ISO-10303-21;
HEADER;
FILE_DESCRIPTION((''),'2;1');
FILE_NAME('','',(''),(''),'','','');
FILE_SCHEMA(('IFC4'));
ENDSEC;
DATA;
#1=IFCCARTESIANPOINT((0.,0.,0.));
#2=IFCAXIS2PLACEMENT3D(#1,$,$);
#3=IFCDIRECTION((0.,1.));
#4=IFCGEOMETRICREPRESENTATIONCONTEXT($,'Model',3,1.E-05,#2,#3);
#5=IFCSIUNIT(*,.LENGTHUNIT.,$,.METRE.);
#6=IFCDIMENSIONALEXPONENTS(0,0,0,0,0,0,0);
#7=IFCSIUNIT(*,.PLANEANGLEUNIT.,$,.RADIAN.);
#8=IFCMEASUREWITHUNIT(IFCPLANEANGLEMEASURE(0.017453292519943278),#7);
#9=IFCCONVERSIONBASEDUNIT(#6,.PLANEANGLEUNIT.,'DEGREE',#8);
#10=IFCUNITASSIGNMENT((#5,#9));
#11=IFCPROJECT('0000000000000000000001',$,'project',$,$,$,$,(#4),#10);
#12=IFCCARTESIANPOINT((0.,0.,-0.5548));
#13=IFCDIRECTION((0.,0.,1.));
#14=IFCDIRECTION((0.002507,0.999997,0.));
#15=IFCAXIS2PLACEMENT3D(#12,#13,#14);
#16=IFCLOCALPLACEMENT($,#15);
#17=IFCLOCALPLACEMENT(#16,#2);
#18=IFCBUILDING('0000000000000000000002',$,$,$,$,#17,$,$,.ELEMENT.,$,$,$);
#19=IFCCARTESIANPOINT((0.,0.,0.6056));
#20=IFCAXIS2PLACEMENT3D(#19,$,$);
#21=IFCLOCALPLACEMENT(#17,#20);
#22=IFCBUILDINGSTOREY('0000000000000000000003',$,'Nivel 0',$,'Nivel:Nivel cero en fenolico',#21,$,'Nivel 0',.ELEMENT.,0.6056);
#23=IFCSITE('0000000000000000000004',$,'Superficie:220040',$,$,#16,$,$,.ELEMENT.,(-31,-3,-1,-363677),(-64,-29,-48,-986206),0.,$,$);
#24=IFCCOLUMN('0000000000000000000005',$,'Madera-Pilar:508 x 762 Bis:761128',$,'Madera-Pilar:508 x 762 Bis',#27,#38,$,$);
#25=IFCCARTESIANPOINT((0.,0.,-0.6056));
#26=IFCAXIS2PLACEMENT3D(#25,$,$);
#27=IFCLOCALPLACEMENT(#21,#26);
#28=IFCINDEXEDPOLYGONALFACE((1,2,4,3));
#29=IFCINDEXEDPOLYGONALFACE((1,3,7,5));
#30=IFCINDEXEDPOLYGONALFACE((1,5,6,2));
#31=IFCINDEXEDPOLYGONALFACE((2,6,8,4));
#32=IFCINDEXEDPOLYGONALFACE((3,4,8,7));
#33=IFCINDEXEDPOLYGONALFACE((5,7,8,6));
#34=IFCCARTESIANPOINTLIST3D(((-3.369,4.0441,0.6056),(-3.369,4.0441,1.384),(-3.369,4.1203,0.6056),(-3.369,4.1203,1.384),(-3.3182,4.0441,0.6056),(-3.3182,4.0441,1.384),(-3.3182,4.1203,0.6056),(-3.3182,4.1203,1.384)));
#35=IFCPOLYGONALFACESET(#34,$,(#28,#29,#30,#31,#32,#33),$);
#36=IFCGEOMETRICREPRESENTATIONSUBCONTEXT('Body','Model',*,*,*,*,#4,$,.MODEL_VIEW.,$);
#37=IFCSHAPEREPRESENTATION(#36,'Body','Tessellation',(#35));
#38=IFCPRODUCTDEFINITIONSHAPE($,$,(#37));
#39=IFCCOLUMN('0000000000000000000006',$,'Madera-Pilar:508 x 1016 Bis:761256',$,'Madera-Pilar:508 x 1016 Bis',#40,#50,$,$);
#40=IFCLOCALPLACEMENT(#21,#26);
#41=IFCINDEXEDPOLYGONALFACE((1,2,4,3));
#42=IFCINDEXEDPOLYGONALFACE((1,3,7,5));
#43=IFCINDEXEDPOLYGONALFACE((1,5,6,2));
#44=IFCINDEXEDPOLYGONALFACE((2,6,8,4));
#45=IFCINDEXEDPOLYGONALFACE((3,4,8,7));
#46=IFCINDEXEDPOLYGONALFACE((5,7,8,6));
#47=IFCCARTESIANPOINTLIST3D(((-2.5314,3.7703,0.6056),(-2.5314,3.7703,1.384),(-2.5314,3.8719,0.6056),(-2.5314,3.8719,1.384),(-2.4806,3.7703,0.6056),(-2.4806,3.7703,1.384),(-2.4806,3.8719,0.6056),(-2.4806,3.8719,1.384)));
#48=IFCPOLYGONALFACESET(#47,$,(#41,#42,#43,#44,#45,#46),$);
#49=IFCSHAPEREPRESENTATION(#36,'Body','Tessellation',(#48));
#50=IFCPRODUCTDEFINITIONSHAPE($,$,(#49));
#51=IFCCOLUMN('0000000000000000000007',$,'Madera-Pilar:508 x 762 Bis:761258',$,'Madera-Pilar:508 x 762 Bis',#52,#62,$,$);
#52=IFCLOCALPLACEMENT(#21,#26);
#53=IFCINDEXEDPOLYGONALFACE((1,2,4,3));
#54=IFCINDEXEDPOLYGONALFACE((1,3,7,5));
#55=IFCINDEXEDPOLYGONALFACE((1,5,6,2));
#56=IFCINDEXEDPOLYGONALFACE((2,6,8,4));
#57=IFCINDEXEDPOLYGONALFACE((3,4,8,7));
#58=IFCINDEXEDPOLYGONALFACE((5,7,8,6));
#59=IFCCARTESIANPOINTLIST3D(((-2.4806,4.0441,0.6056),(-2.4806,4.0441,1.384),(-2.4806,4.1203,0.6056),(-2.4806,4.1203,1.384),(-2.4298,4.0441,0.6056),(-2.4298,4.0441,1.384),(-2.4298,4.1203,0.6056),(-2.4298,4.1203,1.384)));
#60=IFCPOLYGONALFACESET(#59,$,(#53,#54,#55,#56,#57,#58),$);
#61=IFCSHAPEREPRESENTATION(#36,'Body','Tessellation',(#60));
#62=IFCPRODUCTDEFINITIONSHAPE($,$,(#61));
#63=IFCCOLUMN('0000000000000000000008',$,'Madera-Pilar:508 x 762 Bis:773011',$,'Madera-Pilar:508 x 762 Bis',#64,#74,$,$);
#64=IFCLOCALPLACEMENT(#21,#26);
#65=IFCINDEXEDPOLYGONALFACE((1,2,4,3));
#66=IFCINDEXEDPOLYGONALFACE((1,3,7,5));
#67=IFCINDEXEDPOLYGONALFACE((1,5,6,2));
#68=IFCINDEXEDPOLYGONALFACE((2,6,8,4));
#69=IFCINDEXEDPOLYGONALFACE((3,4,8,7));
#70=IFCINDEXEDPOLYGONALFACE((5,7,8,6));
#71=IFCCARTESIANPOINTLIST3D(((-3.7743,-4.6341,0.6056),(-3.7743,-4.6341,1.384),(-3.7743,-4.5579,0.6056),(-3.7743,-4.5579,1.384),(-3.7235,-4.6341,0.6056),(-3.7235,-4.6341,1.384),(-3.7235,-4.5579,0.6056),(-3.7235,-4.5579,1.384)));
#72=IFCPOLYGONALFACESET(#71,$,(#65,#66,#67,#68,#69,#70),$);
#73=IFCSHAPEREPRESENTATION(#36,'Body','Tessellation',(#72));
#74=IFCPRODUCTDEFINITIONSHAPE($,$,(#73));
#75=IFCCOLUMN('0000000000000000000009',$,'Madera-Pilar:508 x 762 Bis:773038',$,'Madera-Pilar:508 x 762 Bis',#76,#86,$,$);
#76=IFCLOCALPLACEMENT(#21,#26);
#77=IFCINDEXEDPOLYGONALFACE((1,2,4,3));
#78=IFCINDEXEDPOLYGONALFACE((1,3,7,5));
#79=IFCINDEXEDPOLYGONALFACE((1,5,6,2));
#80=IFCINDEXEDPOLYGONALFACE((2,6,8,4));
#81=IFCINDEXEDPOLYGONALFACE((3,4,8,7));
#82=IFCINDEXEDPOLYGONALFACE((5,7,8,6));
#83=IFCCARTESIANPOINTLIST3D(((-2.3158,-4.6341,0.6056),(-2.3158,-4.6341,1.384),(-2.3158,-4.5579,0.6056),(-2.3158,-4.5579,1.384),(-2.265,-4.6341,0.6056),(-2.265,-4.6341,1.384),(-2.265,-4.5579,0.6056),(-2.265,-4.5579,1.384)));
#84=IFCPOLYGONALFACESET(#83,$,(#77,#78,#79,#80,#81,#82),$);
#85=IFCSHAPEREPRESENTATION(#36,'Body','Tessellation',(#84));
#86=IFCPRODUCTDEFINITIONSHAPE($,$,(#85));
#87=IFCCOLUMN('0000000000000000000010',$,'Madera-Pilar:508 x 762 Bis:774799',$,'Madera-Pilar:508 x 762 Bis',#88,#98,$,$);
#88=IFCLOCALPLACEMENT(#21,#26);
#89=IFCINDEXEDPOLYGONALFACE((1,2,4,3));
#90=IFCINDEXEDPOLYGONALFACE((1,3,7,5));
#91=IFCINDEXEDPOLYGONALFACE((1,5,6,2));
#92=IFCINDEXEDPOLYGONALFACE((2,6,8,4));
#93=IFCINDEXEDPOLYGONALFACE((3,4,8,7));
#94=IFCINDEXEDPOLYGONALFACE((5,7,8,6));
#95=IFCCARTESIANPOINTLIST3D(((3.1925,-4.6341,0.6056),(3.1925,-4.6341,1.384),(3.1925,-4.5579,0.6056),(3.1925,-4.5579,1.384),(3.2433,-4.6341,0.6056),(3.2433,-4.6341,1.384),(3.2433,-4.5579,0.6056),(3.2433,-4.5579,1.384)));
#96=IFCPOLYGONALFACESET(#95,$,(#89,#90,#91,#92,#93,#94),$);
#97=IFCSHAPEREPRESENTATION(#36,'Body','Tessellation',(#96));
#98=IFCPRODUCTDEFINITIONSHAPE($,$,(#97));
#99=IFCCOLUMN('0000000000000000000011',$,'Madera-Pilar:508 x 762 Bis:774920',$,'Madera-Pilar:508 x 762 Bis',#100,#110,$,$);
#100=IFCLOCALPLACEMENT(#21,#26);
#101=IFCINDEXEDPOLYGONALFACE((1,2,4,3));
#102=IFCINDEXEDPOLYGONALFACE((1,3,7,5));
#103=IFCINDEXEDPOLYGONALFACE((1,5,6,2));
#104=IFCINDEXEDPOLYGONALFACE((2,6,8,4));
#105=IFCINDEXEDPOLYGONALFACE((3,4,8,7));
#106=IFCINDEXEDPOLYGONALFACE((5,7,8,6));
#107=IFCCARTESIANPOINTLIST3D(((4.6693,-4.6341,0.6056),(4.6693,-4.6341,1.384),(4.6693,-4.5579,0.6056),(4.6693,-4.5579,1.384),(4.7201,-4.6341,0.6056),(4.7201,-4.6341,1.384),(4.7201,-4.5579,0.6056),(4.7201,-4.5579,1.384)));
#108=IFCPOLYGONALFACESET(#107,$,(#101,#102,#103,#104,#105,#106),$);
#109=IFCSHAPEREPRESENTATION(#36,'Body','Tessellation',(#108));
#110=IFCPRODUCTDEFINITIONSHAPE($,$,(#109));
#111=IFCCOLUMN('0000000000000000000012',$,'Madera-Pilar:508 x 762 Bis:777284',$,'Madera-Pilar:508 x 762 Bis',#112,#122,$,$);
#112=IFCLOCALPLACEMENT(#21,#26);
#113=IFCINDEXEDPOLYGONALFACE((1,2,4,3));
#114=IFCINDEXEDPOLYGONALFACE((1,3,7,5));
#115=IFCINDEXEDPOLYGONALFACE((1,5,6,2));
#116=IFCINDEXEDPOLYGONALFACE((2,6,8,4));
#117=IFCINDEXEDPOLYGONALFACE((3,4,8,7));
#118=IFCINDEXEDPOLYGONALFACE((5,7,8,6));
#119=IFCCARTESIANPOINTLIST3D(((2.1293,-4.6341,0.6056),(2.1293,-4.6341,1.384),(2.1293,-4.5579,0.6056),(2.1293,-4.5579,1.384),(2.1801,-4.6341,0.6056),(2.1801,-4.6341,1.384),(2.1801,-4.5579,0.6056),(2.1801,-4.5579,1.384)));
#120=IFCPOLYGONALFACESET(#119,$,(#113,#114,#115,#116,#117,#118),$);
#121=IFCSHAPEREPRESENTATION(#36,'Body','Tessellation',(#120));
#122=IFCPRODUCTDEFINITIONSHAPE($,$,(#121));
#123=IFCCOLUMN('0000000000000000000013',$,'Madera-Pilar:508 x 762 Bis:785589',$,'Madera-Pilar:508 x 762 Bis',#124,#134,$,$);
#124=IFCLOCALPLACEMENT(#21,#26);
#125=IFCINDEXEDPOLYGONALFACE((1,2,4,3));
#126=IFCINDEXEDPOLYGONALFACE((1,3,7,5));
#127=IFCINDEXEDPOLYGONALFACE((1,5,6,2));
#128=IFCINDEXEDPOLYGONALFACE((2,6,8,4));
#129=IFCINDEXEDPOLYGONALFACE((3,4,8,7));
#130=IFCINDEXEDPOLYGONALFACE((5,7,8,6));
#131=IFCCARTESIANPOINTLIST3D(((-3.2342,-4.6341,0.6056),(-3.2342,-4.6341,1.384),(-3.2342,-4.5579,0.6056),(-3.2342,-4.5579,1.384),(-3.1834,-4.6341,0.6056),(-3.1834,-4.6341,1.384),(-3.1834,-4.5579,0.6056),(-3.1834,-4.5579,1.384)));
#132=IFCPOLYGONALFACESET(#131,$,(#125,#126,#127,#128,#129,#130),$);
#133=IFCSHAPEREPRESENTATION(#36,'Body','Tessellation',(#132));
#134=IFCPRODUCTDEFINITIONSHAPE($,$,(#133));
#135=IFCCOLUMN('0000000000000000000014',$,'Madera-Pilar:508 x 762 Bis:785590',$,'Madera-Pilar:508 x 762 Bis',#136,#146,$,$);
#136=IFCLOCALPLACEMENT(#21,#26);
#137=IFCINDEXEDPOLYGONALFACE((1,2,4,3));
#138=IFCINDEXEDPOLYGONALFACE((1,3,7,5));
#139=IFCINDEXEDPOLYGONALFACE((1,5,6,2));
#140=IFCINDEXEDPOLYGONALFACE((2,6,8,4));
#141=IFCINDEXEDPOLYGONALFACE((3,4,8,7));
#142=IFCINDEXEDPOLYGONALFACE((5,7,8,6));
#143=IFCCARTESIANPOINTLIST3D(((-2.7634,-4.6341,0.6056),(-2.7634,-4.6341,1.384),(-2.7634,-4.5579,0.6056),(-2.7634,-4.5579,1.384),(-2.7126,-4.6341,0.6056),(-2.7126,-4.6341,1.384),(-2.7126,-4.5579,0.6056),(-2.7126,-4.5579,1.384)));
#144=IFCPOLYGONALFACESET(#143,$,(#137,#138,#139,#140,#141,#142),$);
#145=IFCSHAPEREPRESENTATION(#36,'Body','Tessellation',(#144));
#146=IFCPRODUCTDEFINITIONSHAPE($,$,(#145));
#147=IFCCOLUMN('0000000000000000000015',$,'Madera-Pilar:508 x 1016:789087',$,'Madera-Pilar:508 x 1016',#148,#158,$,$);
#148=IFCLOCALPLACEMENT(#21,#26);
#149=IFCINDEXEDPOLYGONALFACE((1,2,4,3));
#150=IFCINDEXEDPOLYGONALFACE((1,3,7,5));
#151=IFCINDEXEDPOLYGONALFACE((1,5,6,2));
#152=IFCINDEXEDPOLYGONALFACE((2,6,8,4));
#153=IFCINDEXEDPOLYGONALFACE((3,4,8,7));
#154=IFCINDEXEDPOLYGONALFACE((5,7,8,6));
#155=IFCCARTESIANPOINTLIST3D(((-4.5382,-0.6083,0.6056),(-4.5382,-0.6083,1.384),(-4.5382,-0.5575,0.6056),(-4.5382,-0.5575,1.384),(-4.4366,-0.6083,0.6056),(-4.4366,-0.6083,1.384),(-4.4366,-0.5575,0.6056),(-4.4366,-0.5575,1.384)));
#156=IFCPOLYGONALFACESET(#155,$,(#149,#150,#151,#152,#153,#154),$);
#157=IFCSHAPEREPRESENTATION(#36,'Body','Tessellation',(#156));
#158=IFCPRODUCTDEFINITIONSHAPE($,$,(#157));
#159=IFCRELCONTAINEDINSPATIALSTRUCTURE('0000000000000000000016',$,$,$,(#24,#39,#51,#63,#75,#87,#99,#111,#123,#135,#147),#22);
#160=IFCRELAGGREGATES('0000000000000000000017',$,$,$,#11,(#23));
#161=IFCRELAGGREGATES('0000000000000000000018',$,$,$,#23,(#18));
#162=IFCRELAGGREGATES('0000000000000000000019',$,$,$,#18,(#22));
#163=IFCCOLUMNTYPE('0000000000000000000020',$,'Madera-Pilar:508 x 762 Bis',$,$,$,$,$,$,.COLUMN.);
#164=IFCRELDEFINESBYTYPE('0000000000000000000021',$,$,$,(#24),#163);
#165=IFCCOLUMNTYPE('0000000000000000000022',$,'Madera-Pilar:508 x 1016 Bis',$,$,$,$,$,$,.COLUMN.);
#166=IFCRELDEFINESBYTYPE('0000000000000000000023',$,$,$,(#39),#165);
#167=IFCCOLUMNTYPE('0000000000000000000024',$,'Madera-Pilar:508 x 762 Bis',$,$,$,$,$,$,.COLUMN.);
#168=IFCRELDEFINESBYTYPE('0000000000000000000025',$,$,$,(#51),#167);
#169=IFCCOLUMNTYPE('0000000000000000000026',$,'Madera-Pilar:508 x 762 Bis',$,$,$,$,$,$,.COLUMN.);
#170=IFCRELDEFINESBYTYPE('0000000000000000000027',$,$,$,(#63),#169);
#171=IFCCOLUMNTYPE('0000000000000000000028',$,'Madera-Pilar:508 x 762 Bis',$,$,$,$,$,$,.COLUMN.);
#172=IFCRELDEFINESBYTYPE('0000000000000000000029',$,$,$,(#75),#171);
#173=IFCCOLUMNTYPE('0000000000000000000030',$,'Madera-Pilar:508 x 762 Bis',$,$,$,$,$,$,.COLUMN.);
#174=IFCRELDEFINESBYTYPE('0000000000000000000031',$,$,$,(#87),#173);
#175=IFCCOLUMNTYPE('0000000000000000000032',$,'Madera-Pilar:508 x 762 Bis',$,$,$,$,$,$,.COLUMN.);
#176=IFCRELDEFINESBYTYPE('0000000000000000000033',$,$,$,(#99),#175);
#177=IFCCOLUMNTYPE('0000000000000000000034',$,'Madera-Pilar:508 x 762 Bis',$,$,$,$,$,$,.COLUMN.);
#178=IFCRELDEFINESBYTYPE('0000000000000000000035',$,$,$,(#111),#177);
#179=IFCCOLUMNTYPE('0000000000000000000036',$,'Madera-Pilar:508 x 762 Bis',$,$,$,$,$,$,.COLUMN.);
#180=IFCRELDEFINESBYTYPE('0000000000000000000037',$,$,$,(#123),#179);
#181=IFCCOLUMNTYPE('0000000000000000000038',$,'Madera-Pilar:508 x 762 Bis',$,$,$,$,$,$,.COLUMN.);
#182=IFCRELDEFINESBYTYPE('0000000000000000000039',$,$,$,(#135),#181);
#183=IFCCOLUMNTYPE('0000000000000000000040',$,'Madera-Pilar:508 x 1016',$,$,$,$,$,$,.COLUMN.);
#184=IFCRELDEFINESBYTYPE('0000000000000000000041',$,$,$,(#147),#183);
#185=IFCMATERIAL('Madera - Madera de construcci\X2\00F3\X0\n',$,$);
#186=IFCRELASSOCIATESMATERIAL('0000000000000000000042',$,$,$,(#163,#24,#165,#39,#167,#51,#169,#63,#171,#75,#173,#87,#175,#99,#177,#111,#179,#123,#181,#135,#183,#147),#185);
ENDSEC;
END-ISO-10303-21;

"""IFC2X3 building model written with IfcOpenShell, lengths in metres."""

from ifc_helpers import new_model, entity, si_unit, converted_unit, direction, frame, frame_2d, origin, origin_2d_with_axis, place, context, subcontext, project, spatial, rectangle, extrude, source, transform, mapped, material, type_object, type_shapes, element, save


model = new_model("IFC2X3")

# Units and contexts
model_context = context("Model", 3, precision=1e-05, world=origin(), true_north=direction((0.0, 1.0)))
body_context = subcontext(model_context, "Body", "Model", "MODEL_VIEW")
ifc_project = project(units=[si_unit("LENGTHUNIT", "METRE"), converted_unit("PLANEANGLEUNIT", "DEGREE", entity("IfcPlaneAngleMeasure", 0.017453292519943278), si_unit("PLANEANGLEUNIT", "RADIAN"), dimensions=[0, 0, 0, 0, 0, 0, 0])], contexts=[model_context])

# Site, building, storey
site_placement = place(None, frame((0.0, 0.0, -0.5548), z_axis=(0.0, 0.0, 1.0), x_axis=(0.002507, 0.999997, 0.0)))
site = spatial("IfcSite", under=ifc_project, at=site_placement, Name="Superficie:220040", CompositionType="ELEMENT", RefLatitude=(-31, -3, -1, -363677), RefLongitude=(-64, -29, -48, -986206), RefElevation=0.0)
building_placement = place(site_placement, origin())
building = spatial("IfcBuilding", under=site, at=building_placement, CompositionType="ELEMENT")
storey_placement = place(building_placement, frame((0.0, 0.0, 0.6056)))
storey = spatial("IfcBuildingStorey", under=building, at=storey_placement, Name="Nivel 0", ObjectType="Nivel:Nivel cero en fenolico", LongName="Nivel 0", CompositionType="ELEMENT", Elevation=0.6056)

# Columns
ifc_material = material(Name="Madera - Madera de construcción")
column_type_1 = type_object("IfcColumnType", Name="Madera-Pilar:508 x 762 Bis", PredefinedType="COLUMN", material=ifc_material)
shared_shape_1 = source(origin(), body_context, "Body", "SweptSolid", [
    extrude(rectangle(XDim=0.0508, YDim=0.0762, at=frame_2d((0.0, 0.0), x_axis=(1.0, 0.0))), frame((-3.3436, 4.0822, 0.6056), z_axis=(0.0, 0.0, 1.0), x_axis=(-1.0, 0.0, 0.0)), (0.0, 0.0, 1.0), 0.7784),
])
type_shapes(column_type_1, [shared_shape_1])
column_1_placement = place(storey_placement, frame((0.0, 0.0, -0.6056)))
element("IfcColumn", 1, at=column_1_placement, inside=storey, type_object=column_type_1, material=ifc_material, Name="Madera-Pilar:508 x 762 Bis:761128", ObjectType="Madera-Pilar:508 x 762 Bis", context=body_context, shape_type="MappedRepresentation", body=[
    mapped(shared_shape_1, transform((0.0, 0.0, 0.0), scale=1.0)),
])
column_type_2 = type_object("IfcColumnType", Name="Madera-Pilar:508 x 1016 Bis", PredefinedType="COLUMN", material=ifc_material)
shared_shape_2 = source(origin(), body_context, "Body", "SweptSolid", [
    extrude(rectangle(XDim=0.0508, YDim=0.1016, at=frame_2d((0.0, 0.0), x_axis=(1.0, 0.0))), frame((-2.506, 3.8211, 0.6056), z_axis=(0.0, 0.0, 1.0), x_axis=(-1.0, 0.0, 0.0)), (0.0, 0.0, 1.0), 0.7784),
])
type_shapes(column_type_2, [shared_shape_2])
column_2_placement = place(storey_placement, frame((0.0, 0.0, -0.6056)))
element("IfcColumn", 2, at=column_2_placement, inside=storey, type_object=column_type_2, material=ifc_material, Name="Madera-Pilar:508 x 1016 Bis:761256", ObjectType="Madera-Pilar:508 x 1016 Bis", context=body_context, shape_type="MappedRepresentation", body=[
    mapped(shared_shape_2, transform((0.0, 0.0, 0.0), scale=1.0)),
])
column_type_3 = type_object("IfcColumnType", Name="Madera-Pilar:508 x 762 Bis", PredefinedType="COLUMN", material=ifc_material)
shared_shape_3 = source(origin(), body_context, "Body", "SweptSolid", [
    extrude(rectangle(XDim=0.0508, YDim=0.0762, at=frame_2d((0.0, 0.0), x_axis=(1.0, 0.0))), frame((-2.4552, 4.0822, 0.6056), z_axis=(0.0, 0.0, 1.0), x_axis=(-1.0, 0.0, 0.0)), (0.0, 0.0, 1.0), 0.7784),
])
type_shapes(column_type_3, [shared_shape_3])
column_3_placement = place(storey_placement, frame((0.0, 0.0, -0.6056)))
element("IfcColumn", 3, at=column_3_placement, inside=storey, type_object=column_type_3, material=ifc_material, Name="Madera-Pilar:508 x 762 Bis:761258", ObjectType="Madera-Pilar:508 x 762 Bis", context=body_context, shape_type="MappedRepresentation", body=[
    mapped(shared_shape_3, transform((0.0, 0.0, 0.0), scale=1.0)),
])
column_type_4 = type_object("IfcColumnType", Name="Madera-Pilar:508 x 762 Bis", PredefinedType="COLUMN", material=ifc_material)
shared_shape_4 = source(origin(), body_context, "Body", "SweptSolid", [
    extrude(rectangle(XDim=0.0508, YDim=0.0762, at=frame_2d((0.0, 0.0), x_axis=(1.0, 0.0))), frame((-3.7489, -4.596, 0.6056)), (0.0, 0.0, 1.0), 0.7784),
])
type_shapes(column_type_4, [shared_shape_4])
column_4_placement = place(storey_placement, frame((0.0, 0.0, -0.6056)))
element("IfcColumn", 4, at=column_4_placement, inside=storey, type_object=column_type_4, material=ifc_material, Name="Madera-Pilar:508 x 762 Bis:773011", ObjectType="Madera-Pilar:508 x 762 Bis", context=body_context, shape_type="MappedRepresentation", body=[
    mapped(shared_shape_4, transform((0.0, 0.0, 0.0), scale=1.0)),
])
column_type_5 = type_object("IfcColumnType", Name="Madera-Pilar:508 x 762 Bis", PredefinedType="COLUMN", material=ifc_material)
shared_shape_5 = source(origin(), body_context, "Body", "SweptSolid", [
    extrude(rectangle(XDim=0.0508, YDim=0.0762, at=frame_2d((0.0, 0.0), x_axis=(1.0, 0.0))), frame((-2.2904, -4.596, 0.6056)), (0.0, 0.0, 1.0), 0.7784),
])
type_shapes(column_type_5, [shared_shape_5])
column_5_placement = place(storey_placement, frame((0.0, 0.0, -0.6056)))
element("IfcColumn", 5, at=column_5_placement, inside=storey, type_object=column_type_5, material=ifc_material, Name="Madera-Pilar:508 x 762 Bis:773038", ObjectType="Madera-Pilar:508 x 762 Bis", context=body_context, shape_type="MappedRepresentation", body=[
    mapped(shared_shape_5, transform((0.0, 0.0, 0.0), scale=1.0)),
])
column_type_6 = type_object("IfcColumnType", Name="Madera-Pilar:508 x 762 Bis", PredefinedType="COLUMN", material=ifc_material)
shared_shape_6 = source(origin(), body_context, "Body", "SweptSolid", [
    extrude(rectangle(XDim=0.0508, YDim=0.0762, at=frame_2d((0.0, 0.0), x_axis=(1.0, 0.0))), frame((3.2179, -4.596, 0.6056)), (0.0, 0.0, 1.0), 0.7784),
])
type_shapes(column_type_6, [shared_shape_6])
column_6_placement = place(storey_placement, frame((0.0, 0.0, -0.6056)))
element("IfcColumn", 6, at=column_6_placement, inside=storey, type_object=column_type_6, material=ifc_material, Name="Madera-Pilar:508 x 762 Bis:774799", ObjectType="Madera-Pilar:508 x 762 Bis", context=body_context, shape_type="MappedRepresentation", body=[
    mapped(shared_shape_6, transform((0.0, 0.0, 0.0), scale=1.0)),
])
column_type_7 = type_object("IfcColumnType", Name="Madera-Pilar:508 x 762 Bis", PredefinedType="COLUMN", material=ifc_material)
shared_shape_7 = source(origin(), body_context, "Body", "SweptSolid", [
    extrude(rectangle(XDim=0.0508, YDim=0.0762, at=frame_2d((0.0, 0.0), x_axis=(1.0, 0.0))), frame((4.6947, -4.596, 0.6056)), (0.0, 0.0, 1.0), 0.7784),
])
type_shapes(column_type_7, [shared_shape_7])
column_7_placement = place(storey_placement, frame((0.0, 0.0, -0.6056)))
element("IfcColumn", 7, at=column_7_placement, inside=storey, type_object=column_type_7, material=ifc_material, Name="Madera-Pilar:508 x 762 Bis:774920", ObjectType="Madera-Pilar:508 x 762 Bis", context=body_context, shape_type="MappedRepresentation", body=[
    mapped(shared_shape_7, transform((0.0, 0.0, 0.0), scale=1.0)),
])
column_type_8 = type_object("IfcColumnType", Name="Madera-Pilar:508 x 762 Bis", PredefinedType="COLUMN", material=ifc_material)
shared_shape_8 = source(origin(), body_context, "Body", "SweptSolid", [
    extrude(rectangle(XDim=0.0508, YDim=0.0762, at=origin_2d_with_axis()), frame((2.1547, -4.596, 0.6056)), (0.0, 0.0, 1.0), 0.7784),
])
type_shapes(column_type_8, [shared_shape_8])
column_8_placement = place(storey_placement, frame((0.0, 0.0, -0.6056)))
element("IfcColumn", 8, at=column_8_placement, inside=storey, type_object=column_type_8, material=ifc_material, Name="Madera-Pilar:508 x 762 Bis:777284", ObjectType="Madera-Pilar:508 x 762 Bis", context=body_context, shape_type="MappedRepresentation", body=[
    mapped(shared_shape_8, transform((0.0, 0.0, 0.0), scale=1.0)),
])
column_type_9 = type_object("IfcColumnType", Name="Madera-Pilar:508 x 762 Bis", PredefinedType="COLUMN", material=ifc_material)
shared_shape_9 = source(origin(), body_context, "Body", "SweptSolid", [
    extrude(rectangle(XDim=0.0508, YDim=0.0762, at=frame_2d((0.0, 0.0), x_axis=(1.0, 0.0))), frame((-3.2088, -4.596, 0.6056)), (0.0, 0.0, 1.0), 0.7784),
])
type_shapes(column_type_9, [shared_shape_9])
column_9_placement = place(storey_placement, frame((0.0, 0.0, -0.6056)))
element("IfcColumn", 9, at=column_9_placement, inside=storey, type_object=column_type_9, material=ifc_material, Name="Madera-Pilar:508 x 762 Bis:785589", ObjectType="Madera-Pilar:508 x 762 Bis", context=body_context, shape_type="MappedRepresentation", body=[
    mapped(shared_shape_9, transform((0.0, 0.0, 0.0), scale=1.0)),
])
column_type_10 = type_object("IfcColumnType", Name="Madera-Pilar:508 x 762 Bis", PredefinedType="COLUMN", material=ifc_material)
shared_shape_10 = source(origin(), body_context, "Body", "SweptSolid", [
    extrude(rectangle(XDim=0.0508, YDim=0.0762, at=frame_2d((0.0, 0.0), x_axis=(1.0, 0.0))), frame((-2.738, -4.596, 0.6056)), (0.0, 0.0, 1.0), 0.7784),
])
type_shapes(column_type_10, [shared_shape_10])
column_10_placement = place(storey_placement, frame((0.0, 0.0, -0.6056)))
element("IfcColumn", 10, at=column_10_placement, inside=storey, type_object=column_type_10, material=ifc_material, Name="Madera-Pilar:508 x 762 Bis:785590", ObjectType="Madera-Pilar:508 x 762 Bis", context=body_context, shape_type="MappedRepresentation", body=[
    mapped(shared_shape_10, transform((0.0, 0.0, 0.0), scale=1.0)),
])
column_type_11 = type_object("IfcColumnType", Name="Madera-Pilar:508 x 1016", PredefinedType="COLUMN", material=ifc_material)
shared_shape_11 = source(origin(), body_context, "Body", "SweptSolid", [
    extrude(rectangle(XDim=0.1016, YDim=0.0508, at=frame_2d((0.0, 0.0), x_axis=(1.0, 0.0))), frame((-4.4874, -0.5829, 0.6056), z_axis=(0.0, 0.0, 1.0), x_axis=(-1.0, 0.0, 0.0)), (0.0, 0.0, 1.0), 0.7784),
])
type_shapes(column_type_11, [shared_shape_11])
column_11_placement = place(storey_placement, frame((0.0, 0.0, -0.6056)))
element("IfcColumn", 11, at=column_11_placement, inside=storey, type_object=column_type_11, material=ifc_material, Name="Madera-Pilar:508 x 1016:789087", ObjectType="Madera-Pilar:508 x 1016", context=body_context, shape_type="MappedRepresentation", body=[
    mapped(shared_shape_11, transform((0.0, 0.0, 0.0), scale=1.0)),
])

save(model, "model.ifc")
